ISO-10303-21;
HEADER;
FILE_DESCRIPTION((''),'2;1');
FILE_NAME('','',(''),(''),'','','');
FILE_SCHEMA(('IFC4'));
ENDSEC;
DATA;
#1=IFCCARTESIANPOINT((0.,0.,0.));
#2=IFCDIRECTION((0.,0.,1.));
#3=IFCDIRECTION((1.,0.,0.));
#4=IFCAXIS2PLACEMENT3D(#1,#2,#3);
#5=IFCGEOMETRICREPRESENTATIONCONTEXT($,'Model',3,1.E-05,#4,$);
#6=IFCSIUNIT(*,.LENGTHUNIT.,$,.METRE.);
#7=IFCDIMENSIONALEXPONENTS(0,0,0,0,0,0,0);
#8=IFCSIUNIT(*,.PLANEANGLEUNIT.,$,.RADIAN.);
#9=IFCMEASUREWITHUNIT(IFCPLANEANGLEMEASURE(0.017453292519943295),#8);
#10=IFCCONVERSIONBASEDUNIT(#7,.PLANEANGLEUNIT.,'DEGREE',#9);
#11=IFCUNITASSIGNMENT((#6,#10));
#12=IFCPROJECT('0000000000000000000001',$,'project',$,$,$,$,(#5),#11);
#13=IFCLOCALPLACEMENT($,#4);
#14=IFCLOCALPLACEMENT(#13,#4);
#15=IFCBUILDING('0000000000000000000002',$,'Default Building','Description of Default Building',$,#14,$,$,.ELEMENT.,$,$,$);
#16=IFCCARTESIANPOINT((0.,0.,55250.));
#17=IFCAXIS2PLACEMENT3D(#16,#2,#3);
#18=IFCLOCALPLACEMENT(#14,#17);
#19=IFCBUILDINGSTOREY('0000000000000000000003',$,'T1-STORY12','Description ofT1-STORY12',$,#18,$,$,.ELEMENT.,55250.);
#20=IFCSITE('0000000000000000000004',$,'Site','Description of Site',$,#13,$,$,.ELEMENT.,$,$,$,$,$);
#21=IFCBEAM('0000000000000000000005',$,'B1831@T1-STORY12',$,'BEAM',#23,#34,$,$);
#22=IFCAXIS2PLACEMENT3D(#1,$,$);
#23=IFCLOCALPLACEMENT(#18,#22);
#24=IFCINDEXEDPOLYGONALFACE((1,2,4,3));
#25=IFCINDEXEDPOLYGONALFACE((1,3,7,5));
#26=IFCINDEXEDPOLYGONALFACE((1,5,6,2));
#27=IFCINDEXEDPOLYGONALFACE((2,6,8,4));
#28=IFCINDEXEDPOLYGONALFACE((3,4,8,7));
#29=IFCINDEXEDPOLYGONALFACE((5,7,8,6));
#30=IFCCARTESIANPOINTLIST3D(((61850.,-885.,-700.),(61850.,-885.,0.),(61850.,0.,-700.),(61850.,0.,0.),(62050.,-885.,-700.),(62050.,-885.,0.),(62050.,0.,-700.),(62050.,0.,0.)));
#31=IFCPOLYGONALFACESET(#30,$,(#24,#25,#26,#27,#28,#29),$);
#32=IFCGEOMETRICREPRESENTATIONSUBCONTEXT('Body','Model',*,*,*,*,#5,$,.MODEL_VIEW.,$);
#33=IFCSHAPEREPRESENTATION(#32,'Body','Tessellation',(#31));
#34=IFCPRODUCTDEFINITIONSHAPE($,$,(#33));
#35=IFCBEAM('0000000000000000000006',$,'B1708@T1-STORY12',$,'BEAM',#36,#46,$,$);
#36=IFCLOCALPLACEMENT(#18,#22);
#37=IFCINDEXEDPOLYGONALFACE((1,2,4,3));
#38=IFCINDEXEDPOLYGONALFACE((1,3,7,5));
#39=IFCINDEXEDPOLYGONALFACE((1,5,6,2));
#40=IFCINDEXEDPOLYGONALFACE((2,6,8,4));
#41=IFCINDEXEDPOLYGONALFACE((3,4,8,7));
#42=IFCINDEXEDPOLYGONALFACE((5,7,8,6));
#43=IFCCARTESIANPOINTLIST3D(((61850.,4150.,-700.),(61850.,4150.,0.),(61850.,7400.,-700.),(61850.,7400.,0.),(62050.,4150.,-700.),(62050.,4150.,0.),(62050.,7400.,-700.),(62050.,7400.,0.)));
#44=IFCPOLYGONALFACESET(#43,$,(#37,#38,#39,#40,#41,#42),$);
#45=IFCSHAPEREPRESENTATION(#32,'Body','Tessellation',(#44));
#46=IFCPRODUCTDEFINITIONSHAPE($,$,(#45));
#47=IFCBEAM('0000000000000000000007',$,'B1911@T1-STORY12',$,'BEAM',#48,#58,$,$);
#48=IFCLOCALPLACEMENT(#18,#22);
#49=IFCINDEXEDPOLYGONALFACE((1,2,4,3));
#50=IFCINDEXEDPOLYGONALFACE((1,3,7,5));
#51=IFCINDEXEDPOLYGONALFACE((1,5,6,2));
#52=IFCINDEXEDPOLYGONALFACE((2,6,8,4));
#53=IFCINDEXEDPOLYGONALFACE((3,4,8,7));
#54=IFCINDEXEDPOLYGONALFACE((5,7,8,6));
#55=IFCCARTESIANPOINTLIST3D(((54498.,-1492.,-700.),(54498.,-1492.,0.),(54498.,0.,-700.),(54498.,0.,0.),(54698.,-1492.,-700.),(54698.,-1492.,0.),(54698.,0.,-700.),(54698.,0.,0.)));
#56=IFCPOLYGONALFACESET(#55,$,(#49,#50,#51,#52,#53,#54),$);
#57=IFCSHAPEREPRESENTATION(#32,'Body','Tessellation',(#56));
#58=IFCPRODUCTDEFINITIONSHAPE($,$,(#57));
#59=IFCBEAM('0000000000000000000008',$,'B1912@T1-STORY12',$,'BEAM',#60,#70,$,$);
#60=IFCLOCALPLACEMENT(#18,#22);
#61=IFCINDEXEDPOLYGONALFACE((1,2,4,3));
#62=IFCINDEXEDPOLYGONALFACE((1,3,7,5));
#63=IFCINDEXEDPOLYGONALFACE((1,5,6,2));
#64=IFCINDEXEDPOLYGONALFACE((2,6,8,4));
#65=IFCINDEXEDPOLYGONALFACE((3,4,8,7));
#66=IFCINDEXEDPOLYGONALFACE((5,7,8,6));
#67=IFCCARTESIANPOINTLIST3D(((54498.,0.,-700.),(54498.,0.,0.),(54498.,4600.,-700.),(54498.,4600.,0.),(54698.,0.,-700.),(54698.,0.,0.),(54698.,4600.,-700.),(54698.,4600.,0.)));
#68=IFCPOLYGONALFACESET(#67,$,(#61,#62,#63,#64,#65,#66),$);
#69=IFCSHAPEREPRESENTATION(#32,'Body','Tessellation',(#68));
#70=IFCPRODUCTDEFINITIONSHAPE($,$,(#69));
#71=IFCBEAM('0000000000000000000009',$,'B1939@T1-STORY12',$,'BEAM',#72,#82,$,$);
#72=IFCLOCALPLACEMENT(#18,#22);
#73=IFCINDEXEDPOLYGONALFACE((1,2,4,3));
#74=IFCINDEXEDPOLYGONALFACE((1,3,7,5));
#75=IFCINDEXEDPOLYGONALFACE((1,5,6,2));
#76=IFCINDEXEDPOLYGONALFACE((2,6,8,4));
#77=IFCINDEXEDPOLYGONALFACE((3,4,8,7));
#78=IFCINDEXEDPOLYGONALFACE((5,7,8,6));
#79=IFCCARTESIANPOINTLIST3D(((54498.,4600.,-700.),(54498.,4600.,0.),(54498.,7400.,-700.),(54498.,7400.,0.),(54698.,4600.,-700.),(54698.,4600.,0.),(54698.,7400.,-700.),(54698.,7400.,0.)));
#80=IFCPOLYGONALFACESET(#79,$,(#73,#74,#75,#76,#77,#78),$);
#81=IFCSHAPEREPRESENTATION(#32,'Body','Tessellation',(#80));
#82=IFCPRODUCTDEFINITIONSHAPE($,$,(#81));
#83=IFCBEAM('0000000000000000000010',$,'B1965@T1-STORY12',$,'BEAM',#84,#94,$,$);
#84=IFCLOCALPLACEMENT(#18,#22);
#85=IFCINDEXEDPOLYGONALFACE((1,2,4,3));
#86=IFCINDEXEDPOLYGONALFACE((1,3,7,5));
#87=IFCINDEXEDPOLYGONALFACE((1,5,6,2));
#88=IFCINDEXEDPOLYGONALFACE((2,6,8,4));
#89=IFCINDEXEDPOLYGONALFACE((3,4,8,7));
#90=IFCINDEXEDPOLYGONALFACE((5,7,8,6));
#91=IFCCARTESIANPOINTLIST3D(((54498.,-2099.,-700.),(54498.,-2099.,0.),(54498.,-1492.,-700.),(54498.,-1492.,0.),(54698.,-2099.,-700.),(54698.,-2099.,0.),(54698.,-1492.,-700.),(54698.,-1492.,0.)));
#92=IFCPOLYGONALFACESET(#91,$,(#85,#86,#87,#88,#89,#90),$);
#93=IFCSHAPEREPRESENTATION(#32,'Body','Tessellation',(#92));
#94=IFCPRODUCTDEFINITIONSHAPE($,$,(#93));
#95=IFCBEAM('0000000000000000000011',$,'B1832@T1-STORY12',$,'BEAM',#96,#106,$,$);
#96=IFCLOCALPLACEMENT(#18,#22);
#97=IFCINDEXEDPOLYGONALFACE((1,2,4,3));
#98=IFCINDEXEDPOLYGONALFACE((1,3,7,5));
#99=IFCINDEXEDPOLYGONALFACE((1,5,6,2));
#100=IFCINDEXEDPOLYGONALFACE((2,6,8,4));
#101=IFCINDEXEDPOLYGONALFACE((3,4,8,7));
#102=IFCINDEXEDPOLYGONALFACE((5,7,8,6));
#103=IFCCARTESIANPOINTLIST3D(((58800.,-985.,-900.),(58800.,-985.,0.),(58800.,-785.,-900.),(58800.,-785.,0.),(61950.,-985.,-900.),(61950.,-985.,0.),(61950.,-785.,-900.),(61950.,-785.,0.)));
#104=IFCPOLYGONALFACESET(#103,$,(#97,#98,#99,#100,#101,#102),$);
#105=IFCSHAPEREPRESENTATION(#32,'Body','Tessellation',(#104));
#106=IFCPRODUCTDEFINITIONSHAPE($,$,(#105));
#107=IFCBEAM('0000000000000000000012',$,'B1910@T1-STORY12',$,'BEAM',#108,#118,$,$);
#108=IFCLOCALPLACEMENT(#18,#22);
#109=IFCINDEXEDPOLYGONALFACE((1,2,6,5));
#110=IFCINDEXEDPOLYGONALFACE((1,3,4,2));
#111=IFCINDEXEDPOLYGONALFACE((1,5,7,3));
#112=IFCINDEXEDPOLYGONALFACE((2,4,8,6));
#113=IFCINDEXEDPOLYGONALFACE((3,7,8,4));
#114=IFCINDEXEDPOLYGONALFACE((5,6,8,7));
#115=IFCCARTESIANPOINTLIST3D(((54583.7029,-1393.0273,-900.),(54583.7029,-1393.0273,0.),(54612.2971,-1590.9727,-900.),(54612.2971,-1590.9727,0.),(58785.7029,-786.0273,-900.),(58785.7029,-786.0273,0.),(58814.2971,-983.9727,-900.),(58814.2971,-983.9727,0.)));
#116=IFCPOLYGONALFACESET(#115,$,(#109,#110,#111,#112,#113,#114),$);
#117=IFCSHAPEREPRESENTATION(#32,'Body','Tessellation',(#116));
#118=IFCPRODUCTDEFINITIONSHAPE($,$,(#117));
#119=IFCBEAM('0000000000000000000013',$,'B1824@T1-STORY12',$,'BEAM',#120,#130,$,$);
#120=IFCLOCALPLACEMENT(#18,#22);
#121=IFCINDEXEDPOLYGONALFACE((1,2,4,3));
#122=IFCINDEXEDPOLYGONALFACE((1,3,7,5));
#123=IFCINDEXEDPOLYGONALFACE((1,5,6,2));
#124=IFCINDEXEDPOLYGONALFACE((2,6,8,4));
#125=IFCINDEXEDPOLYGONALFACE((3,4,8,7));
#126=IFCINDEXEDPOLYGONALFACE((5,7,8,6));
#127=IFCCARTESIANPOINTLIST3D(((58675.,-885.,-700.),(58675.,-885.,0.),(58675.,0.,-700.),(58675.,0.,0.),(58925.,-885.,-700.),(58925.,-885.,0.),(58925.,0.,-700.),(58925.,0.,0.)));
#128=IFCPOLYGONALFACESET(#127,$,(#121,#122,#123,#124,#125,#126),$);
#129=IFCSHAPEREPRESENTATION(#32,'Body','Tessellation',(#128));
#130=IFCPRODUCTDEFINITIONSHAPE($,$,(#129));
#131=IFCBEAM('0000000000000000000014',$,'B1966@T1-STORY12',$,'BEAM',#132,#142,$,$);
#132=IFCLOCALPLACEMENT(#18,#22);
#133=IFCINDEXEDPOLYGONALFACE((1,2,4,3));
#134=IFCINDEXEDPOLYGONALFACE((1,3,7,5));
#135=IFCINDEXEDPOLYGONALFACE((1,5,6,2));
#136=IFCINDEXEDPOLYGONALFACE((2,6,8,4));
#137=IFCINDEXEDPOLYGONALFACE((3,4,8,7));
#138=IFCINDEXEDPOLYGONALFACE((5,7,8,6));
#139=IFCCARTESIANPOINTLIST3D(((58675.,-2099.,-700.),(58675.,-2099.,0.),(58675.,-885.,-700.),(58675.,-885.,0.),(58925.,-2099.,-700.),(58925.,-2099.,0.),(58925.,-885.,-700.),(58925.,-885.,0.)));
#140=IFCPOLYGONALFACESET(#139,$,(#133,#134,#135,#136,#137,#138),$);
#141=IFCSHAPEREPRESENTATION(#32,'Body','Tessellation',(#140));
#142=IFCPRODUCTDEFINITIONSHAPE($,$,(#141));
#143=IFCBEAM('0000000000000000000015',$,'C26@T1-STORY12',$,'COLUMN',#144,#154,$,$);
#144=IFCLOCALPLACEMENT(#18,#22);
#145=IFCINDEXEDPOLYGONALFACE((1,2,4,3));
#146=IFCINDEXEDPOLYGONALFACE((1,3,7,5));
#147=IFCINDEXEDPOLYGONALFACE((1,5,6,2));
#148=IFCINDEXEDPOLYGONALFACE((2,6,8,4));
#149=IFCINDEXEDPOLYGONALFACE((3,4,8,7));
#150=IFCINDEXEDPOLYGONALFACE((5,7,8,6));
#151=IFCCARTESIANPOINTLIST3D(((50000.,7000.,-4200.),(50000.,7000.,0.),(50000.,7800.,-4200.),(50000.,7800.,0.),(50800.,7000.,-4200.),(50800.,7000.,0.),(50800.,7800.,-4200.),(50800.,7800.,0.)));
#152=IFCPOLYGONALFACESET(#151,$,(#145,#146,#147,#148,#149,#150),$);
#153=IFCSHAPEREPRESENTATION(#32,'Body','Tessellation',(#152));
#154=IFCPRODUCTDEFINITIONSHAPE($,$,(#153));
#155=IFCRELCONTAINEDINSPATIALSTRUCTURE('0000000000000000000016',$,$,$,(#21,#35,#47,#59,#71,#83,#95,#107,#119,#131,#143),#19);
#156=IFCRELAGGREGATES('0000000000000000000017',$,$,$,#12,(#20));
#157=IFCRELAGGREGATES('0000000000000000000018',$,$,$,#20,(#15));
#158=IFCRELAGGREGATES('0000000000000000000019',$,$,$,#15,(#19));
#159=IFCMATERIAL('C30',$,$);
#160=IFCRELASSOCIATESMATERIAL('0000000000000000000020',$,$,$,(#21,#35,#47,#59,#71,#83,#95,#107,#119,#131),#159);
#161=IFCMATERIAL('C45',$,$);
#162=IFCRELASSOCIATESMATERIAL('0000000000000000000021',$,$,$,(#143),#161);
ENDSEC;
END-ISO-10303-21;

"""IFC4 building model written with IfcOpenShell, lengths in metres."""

from ifc_helpers import new_model, entity, si_unit, converted_unit, frame, origin_with_axes, place, context, subcontext, project, spatial, rectangle, extrude, material, element, save


model = new_model("IFC4")

# Units and contexts
model_context = context("Model", 3, precision=1e-05, world=origin_with_axes())
body_context = subcontext(model_context, "Body", "Model", "MODEL_VIEW")
ifc_project = project(units=[si_unit("LENGTHUNIT", "METRE"), converted_unit("PLANEANGLEUNIT", "DEGREE", entity("IfcPlaneAngleMeasure", 0.017453292519943295), si_unit("PLANEANGLEUNIT", "RADIAN"), dimensions=[0, 0, 0, 0, 0, 0, 0])], contexts=[model_context])

# Site, building, storey
site_placement = place(None, origin_with_axes())
site = spatial("IfcSite", under=ifc_project, at=site_placement, Name="Site", Description="Description of Site", CompositionType="ELEMENT")
building_placement = place(site_placement, origin_with_axes())
building = spatial("IfcBuilding", under=site, at=building_placement, Name="Default Building", Description="Description of Default Building", CompositionType="ELEMENT")
storey_placement = place(building_placement, frame((0.0, 0.0, 55250.0), z_axis=(0.0, 0.0, 1.0), x_axis=(1.0, 0.0, 0.0)))
storey = spatial("IfcBuildingStorey", under=building, at=storey_placement, Name="T1-STORY12", Description="Description ofT1-STORY12", CompositionType="ELEMENT", Elevation=55250.0)

# Beams
ifc_material_1 = material(Name="C30")
beam_1_placement = place(storey_placement, frame((61950.0, -885.0, -350.0), z_axis=(0.0, 1.0, 0.0), x_axis=(-1.0, 0.0, 0.0)))
element("IfcBeam", 1, at=beam_1_placement, inside=storey, material=ifc_material_1, Name="B1831@T1-STORY12", ObjectType="BEAM", context=body_context, shape_type="SweptSolid", body=[
    extrude(rectangle(XDim=200.0, YDim=700.0), origin_with_axes(), (0.0, 0.0, 1.0), 885.0),
])
beam_2_placement = place(storey_placement, frame((61950.0, 4150.0, -350.0), z_axis=(0.0, 1.0, 0.0), x_axis=(-1.0, 0.0, 0.0)))
element("IfcBeam", 2, at=beam_2_placement, inside=storey, material=ifc_material_1, Name="B1708@T1-STORY12", ObjectType="BEAM", context=body_context, shape_type="SweptSolid", body=[
    extrude(rectangle(XDim=200.0, YDim=700.0), origin_with_axes(), (0.0, 0.0, 1.0), 3250.0),
])
beam_3_placement = place(storey_placement, frame((54598.0, -1492.0, -350.0), z_axis=(0.0, 1.0, 0.0), x_axis=(-1.0, 0.0, 0.0)))
element("IfcBeam", 3, at=beam_3_placement, inside=storey, material=ifc_material_1, Name="B1911@T1-STORY12", ObjectType="BEAM", context=body_context, shape_type="SweptSolid", body=[
    extrude(rectangle(XDim=200.0, YDim=700.0), origin_with_axes(), (0.0, 0.0, 1.0), 1492.0),
])
beam_4_placement = place(storey_placement, frame((54598.0, 0.0, -350.0), z_axis=(0.0, 1.0, 0.0), x_axis=(-1.0, 0.0, 0.0)))
element("IfcBeam", 4, at=beam_4_placement, inside=storey, material=ifc_material_1, Name="B1912@T1-STORY12", ObjectType="BEAM", context=body_context, shape_type="SweptSolid", body=[
    extrude(rectangle(XDim=200.0, YDim=700.0), origin_with_axes(), (0.0, 0.0, 1.0), 4600.0),
])
beam_5_placement = place(storey_placement, frame((54598.0, 4600.0, -350.0), z_axis=(0.0, 1.0, 0.0), x_axis=(-1.0, 0.0, 0.0)))
element("IfcBeam", 5, at=beam_5_placement, inside=storey, material=ifc_material_1, Name="B1939@T1-STORY12", ObjectType="BEAM", context=body_context, shape_type="SweptSolid", body=[
    extrude(rectangle(XDim=200.0, YDim=700.0), origin_with_axes(), (0.0, 0.0, 1.0), 2800.0),
])
beam_6_placement = place(storey_placement, frame((54598.0, -2099.0, -350.0), z_axis=(0.0, 1.0, 0.0), x_axis=(-1.0, 0.0, 0.0)))
element("IfcBeam", 6, at=beam_6_placement, inside=storey, material=ifc_material_1, Name="B1965@T1-STORY12", ObjectType="BEAM", context=body_context, shape_type="SweptSolid", body=[
    extrude(rectangle(XDim=200.0, YDim=700.0), origin_with_axes(), (0.0, 0.0, 1.0), 607.0),
])
beam_7_placement = place(storey_placement, frame((58800.0, -885.0, -450.0), z_axis=(1.0, 0.0, 0.0), x_axis=(0.0, 1.0, 0.0)))
element("IfcBeam", 7, at=beam_7_placement, inside=storey, material=ifc_material_1, Name="B1832@T1-STORY12", ObjectType="BEAM", context=body_context, shape_type="SweptSolid", body=[
    extrude(rectangle(XDim=200.0, YDim=900.0), origin_with_axes(), (0.0, 0.0, 1.0), 3150.0),
])
beam_8_placement = place(storey_placement, frame((54598.0, -1492.0, -450.0), z_axis=(0.989727, 0.142971, 0.0), x_axis=(-0.142971, 0.989727, 0.0)))
element("IfcBeam", 8, at=beam_8_placement, inside=storey, material=ifc_material_1, Name="B1910@T1-STORY12", ObjectType="BEAM", context=body_context, shape_type="SweptSolid", body=[
    extrude(rectangle(XDim=200.0, YDim=900.0), origin_with_axes(), (0.0, 0.0, 1.0), 4245.6157),
])
beam_9_placement = place(storey_placement, frame((58800.0, -885.0, -350.0), z_axis=(0.0, 1.0, 0.0), x_axis=(-1.0, 0.0, 0.0)))
element("IfcBeam", 9, at=beam_9_placement, inside=storey, material=ifc_material_1, Name="B1824@T1-STORY12", ObjectType="BEAM", context=body_context, shape_type="SweptSolid", body=[
    extrude(rectangle(XDim=250.0, YDim=700.0), origin_with_axes(), (0.0, 0.0, 1.0), 885.0),
])
beam_10_placement = place(storey_placement, frame((58800.0, -2099.0, -350.0), z_axis=(0.0, 1.0, 0.0), x_axis=(-1.0, 0.0, 0.0)))
element("IfcBeam", 10, at=beam_10_placement, inside=storey, material=ifc_material_1, Name="B1966@T1-STORY12", ObjectType="BEAM", context=body_context, shape_type="SweptSolid", body=[
    extrude(rectangle(XDim=250.0, YDim=700.0), origin_with_axes(), (0.0, 0.0, 1.0), 1214.0),
])
ifc_material_2 = material(Name="C45")
beam_11_placement = place(storey_placement, frame((50400.0, 7400.0, -4200.0), z_axis=(0.0, 0.0, 1.0), x_axis=(-1.0, 0.0, 0.0)))
element("IfcBeam", 11, at=beam_11_placement, inside=storey, material=ifc_material_2, Name="C26@T1-STORY12", ObjectType="COLUMN", context=body_context, shape_type="SweptSolid", body=[
    extrude(rectangle(XDim=800.0, YDim=800.0), origin_with_axes(), (0.0, 0.0, 1.0), 4200.0),
])

save(model, "model.ifc")
